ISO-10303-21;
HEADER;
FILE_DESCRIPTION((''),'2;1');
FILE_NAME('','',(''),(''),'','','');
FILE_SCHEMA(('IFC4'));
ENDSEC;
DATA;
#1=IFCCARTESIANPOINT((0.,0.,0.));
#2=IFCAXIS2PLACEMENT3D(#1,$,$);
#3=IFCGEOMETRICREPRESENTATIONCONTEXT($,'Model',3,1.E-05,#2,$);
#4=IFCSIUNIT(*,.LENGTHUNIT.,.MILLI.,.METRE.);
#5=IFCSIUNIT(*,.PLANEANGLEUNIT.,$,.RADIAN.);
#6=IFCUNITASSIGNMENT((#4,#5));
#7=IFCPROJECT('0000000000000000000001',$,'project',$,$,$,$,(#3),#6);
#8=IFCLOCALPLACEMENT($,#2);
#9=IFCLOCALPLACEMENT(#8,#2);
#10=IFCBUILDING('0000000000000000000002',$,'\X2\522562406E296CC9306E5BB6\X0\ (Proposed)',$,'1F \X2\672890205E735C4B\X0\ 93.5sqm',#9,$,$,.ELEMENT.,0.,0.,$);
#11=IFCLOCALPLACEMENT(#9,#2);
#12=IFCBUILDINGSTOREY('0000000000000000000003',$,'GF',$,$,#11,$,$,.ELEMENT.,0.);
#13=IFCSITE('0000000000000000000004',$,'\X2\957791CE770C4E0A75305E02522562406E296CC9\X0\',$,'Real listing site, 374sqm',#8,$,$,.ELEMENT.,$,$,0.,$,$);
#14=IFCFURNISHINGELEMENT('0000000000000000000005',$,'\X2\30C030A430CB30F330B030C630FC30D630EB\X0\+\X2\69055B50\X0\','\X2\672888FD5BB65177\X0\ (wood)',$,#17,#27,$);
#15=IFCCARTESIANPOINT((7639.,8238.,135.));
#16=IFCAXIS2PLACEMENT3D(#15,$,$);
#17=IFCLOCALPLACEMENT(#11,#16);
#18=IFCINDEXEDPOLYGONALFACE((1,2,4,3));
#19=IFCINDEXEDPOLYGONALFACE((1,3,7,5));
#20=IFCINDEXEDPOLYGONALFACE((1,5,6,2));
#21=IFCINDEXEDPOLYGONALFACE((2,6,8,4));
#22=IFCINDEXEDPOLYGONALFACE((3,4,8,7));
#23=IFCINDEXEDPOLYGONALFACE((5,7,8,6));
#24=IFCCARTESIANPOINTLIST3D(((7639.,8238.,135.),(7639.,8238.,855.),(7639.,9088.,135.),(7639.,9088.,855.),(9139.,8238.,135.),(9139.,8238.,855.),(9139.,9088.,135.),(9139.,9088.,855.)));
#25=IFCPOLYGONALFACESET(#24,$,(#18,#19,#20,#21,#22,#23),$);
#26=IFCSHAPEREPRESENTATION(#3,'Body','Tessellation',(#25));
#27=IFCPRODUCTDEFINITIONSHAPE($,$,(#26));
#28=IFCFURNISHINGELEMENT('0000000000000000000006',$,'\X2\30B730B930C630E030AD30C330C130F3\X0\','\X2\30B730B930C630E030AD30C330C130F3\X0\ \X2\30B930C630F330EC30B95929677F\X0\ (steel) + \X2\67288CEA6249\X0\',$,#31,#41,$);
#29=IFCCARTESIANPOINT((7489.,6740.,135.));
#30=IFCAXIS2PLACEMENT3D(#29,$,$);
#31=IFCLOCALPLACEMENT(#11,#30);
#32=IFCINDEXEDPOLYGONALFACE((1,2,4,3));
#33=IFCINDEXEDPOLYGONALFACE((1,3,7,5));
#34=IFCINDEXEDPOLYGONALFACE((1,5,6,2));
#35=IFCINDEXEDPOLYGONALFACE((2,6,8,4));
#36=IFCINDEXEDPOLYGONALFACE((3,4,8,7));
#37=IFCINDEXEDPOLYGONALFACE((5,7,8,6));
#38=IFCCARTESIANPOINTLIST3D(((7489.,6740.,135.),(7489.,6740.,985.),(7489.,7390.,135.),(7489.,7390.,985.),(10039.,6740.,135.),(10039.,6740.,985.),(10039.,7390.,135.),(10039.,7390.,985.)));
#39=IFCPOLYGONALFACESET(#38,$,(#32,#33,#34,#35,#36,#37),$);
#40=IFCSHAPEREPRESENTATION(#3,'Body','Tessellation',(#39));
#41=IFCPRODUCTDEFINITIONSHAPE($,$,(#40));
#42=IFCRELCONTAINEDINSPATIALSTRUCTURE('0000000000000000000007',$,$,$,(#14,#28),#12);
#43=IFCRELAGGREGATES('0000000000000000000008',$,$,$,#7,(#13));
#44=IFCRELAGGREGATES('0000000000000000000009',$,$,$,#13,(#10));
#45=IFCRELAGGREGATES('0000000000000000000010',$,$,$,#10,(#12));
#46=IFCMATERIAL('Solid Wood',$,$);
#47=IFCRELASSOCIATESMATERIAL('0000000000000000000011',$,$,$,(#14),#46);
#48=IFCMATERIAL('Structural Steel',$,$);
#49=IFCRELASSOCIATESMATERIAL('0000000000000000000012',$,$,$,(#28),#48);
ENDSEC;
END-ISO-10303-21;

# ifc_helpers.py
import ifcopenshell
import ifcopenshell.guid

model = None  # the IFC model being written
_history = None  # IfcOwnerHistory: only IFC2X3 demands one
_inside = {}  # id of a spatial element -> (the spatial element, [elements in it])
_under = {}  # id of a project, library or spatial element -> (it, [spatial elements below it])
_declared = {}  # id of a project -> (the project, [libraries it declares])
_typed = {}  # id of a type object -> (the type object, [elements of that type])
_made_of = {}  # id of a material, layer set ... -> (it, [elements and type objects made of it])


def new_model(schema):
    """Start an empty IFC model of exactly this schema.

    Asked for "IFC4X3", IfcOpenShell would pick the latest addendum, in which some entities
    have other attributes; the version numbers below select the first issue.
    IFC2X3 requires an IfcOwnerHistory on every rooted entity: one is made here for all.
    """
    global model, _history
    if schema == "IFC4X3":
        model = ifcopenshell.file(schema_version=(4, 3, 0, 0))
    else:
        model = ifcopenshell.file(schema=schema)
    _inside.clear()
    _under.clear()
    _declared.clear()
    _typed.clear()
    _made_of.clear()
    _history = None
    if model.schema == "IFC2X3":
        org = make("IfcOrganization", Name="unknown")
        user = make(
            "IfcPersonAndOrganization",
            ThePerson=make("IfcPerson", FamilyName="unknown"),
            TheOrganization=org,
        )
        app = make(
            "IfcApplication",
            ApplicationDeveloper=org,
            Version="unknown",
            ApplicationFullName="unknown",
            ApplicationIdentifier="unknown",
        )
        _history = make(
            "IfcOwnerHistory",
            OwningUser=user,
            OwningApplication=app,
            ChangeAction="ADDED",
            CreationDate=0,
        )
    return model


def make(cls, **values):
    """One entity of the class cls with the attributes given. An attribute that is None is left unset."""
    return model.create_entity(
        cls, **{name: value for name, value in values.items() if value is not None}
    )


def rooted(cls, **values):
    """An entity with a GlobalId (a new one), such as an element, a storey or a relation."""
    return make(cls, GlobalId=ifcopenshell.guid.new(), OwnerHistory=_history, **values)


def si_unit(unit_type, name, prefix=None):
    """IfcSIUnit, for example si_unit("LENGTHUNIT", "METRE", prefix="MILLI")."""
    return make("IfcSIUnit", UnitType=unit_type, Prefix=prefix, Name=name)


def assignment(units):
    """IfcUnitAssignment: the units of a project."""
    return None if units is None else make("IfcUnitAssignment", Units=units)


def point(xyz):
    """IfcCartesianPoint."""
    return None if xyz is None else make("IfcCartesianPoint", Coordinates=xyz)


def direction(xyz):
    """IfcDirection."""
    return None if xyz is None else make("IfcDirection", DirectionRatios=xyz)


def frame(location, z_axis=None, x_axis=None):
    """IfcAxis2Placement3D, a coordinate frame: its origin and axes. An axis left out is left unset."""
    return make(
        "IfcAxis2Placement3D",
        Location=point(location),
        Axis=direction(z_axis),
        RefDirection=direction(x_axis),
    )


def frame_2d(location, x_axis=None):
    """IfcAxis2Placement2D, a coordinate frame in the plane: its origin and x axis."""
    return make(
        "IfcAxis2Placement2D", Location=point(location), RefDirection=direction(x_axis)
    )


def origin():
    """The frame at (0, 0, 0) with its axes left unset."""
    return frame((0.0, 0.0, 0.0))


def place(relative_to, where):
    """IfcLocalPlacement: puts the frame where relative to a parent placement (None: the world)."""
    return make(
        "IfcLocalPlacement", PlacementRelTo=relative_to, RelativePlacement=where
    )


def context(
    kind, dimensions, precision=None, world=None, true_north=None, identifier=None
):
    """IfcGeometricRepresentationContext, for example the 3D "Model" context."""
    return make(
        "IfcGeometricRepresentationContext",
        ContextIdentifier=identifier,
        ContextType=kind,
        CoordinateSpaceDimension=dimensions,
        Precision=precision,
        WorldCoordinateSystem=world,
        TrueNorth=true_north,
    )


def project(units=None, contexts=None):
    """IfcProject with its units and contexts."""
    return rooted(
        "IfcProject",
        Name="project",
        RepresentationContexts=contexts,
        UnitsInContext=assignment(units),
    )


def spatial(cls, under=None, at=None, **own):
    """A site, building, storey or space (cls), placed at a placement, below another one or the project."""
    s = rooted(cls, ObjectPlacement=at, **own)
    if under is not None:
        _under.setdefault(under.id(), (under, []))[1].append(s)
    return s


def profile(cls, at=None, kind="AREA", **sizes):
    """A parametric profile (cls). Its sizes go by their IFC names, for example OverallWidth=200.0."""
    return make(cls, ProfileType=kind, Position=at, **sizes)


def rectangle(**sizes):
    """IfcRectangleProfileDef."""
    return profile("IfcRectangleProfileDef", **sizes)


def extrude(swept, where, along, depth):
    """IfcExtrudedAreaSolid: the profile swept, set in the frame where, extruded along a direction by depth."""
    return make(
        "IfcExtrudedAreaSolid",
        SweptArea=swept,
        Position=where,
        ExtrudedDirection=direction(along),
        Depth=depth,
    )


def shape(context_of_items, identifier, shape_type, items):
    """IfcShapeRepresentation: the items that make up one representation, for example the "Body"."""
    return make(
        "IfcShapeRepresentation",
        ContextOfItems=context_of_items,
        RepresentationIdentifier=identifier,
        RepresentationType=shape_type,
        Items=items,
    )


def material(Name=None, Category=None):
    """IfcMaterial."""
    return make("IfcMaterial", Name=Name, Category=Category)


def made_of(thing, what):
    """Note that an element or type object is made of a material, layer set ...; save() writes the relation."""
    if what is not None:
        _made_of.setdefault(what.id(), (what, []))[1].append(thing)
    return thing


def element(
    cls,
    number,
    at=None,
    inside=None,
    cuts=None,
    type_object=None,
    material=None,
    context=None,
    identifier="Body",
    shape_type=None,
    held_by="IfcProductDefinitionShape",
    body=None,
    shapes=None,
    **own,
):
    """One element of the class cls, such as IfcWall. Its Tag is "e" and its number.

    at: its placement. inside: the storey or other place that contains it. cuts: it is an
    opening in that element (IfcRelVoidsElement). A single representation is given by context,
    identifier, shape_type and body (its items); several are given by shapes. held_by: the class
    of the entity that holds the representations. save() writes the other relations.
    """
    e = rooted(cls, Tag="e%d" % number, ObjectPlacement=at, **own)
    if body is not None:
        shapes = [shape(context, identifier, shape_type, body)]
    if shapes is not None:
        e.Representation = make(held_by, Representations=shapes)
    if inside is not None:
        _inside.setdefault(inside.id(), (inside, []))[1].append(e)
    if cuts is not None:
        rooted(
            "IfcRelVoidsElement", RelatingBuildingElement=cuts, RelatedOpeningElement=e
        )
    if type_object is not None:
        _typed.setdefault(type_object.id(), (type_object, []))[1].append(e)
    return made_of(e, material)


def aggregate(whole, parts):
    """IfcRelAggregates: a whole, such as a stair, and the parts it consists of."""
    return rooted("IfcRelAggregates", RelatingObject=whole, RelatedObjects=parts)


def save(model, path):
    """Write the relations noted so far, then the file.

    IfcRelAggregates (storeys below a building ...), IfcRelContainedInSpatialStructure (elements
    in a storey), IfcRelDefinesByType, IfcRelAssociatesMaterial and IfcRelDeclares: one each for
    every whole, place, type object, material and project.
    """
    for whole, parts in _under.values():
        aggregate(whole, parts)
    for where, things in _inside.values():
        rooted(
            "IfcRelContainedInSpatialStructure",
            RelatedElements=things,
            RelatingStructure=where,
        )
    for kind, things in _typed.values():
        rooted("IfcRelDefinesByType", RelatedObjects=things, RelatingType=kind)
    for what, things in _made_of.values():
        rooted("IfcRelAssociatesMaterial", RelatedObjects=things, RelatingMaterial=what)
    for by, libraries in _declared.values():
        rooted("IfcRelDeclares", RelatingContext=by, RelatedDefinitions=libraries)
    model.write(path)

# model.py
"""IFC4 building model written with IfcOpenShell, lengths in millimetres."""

from ifc_helpers import new_model, si_unit, frame, frame_2d, origin, place, context, project, spatial, rectangle, extrude, material, element, save


model = new_model("IFC4")

# Units and contexts
model_context = context("Model", 3, precision=1e-05, world=origin())
ifc_project = project(units=[si_unit("LENGTHUNIT", "METRE", prefix="MILLI"), si_unit("PLANEANGLEUNIT", "RADIAN")], contexts=[model_context])

# Site, building, storey
site_placement = place(None, origin())
site = spatial("IfcSite", under=ifc_project, at=site_placement, Name="長野県上田市別所温泉", ObjectType="Real listing site, 374sqm", CompositionType="ELEMENT", RefElevation=0.0)
building_placement = place(site_placement, origin())
building = spatial("IfcBuilding", under=site, at=building_placement, Name="別所温泉の家 (Proposed)", ObjectType="1F 木造平屋 93.5sqm", CompositionType="ELEMENT", ElevationOfRefHeight=0.0, ElevationOfTerrain=0.0)
storey_placement = place(building_placement, origin())
storey = spatial("IfcBuildingStorey", under=building, at=storey_placement, Name="GF", CompositionType="ELEMENT", Elevation=0.0)

# Shared definitions
ifc_material_1 = material(Name="Solid Wood")

# Shared definitions
ifc_material_2 = material(Name="Structural Steel")

# Furnishing elements
furnishing_1_placement = place(storey_placement, frame((7639.0, 8238.0, 135.0)))
element("IfcFurnishingElement", 1, at=furnishing_1_placement, inside=storey, material=ifc_material_1, Name="ダイニングテーブル+椅子", Description="木製家具 (wood)", context=model_context, shape_type="SweptSolid", body=[
    extrude(rectangle(XDim=1500.0, YDim=850.0, at=frame_2d((750.0, 425.0))), frame((7639.0, 8238.0, 135.0)), (0.0, 0.0, 1.0), 720.0),
])
furnishing_2_placement = place(storey_placement, frame((7489.0, 6740.0, 135.0)))
element("IfcFurnishingElement", 2, at=furnishing_2_placement, inside=storey, material=ifc_material_2, Name="システムキッチン", Description="システムキッチン ステンレス天板 (steel) + 木質扉", context=model_context, shape_type="SweptSolid", body=[
    extrude(rectangle(XDim=2550.0, YDim=650.0, at=frame_2d((1275.0, 325.0))), frame((7489.0, 6740.0, 135.0)), (0.0, 0.0, 1.0), 850.0),
])

save(model, "model.ifc")
